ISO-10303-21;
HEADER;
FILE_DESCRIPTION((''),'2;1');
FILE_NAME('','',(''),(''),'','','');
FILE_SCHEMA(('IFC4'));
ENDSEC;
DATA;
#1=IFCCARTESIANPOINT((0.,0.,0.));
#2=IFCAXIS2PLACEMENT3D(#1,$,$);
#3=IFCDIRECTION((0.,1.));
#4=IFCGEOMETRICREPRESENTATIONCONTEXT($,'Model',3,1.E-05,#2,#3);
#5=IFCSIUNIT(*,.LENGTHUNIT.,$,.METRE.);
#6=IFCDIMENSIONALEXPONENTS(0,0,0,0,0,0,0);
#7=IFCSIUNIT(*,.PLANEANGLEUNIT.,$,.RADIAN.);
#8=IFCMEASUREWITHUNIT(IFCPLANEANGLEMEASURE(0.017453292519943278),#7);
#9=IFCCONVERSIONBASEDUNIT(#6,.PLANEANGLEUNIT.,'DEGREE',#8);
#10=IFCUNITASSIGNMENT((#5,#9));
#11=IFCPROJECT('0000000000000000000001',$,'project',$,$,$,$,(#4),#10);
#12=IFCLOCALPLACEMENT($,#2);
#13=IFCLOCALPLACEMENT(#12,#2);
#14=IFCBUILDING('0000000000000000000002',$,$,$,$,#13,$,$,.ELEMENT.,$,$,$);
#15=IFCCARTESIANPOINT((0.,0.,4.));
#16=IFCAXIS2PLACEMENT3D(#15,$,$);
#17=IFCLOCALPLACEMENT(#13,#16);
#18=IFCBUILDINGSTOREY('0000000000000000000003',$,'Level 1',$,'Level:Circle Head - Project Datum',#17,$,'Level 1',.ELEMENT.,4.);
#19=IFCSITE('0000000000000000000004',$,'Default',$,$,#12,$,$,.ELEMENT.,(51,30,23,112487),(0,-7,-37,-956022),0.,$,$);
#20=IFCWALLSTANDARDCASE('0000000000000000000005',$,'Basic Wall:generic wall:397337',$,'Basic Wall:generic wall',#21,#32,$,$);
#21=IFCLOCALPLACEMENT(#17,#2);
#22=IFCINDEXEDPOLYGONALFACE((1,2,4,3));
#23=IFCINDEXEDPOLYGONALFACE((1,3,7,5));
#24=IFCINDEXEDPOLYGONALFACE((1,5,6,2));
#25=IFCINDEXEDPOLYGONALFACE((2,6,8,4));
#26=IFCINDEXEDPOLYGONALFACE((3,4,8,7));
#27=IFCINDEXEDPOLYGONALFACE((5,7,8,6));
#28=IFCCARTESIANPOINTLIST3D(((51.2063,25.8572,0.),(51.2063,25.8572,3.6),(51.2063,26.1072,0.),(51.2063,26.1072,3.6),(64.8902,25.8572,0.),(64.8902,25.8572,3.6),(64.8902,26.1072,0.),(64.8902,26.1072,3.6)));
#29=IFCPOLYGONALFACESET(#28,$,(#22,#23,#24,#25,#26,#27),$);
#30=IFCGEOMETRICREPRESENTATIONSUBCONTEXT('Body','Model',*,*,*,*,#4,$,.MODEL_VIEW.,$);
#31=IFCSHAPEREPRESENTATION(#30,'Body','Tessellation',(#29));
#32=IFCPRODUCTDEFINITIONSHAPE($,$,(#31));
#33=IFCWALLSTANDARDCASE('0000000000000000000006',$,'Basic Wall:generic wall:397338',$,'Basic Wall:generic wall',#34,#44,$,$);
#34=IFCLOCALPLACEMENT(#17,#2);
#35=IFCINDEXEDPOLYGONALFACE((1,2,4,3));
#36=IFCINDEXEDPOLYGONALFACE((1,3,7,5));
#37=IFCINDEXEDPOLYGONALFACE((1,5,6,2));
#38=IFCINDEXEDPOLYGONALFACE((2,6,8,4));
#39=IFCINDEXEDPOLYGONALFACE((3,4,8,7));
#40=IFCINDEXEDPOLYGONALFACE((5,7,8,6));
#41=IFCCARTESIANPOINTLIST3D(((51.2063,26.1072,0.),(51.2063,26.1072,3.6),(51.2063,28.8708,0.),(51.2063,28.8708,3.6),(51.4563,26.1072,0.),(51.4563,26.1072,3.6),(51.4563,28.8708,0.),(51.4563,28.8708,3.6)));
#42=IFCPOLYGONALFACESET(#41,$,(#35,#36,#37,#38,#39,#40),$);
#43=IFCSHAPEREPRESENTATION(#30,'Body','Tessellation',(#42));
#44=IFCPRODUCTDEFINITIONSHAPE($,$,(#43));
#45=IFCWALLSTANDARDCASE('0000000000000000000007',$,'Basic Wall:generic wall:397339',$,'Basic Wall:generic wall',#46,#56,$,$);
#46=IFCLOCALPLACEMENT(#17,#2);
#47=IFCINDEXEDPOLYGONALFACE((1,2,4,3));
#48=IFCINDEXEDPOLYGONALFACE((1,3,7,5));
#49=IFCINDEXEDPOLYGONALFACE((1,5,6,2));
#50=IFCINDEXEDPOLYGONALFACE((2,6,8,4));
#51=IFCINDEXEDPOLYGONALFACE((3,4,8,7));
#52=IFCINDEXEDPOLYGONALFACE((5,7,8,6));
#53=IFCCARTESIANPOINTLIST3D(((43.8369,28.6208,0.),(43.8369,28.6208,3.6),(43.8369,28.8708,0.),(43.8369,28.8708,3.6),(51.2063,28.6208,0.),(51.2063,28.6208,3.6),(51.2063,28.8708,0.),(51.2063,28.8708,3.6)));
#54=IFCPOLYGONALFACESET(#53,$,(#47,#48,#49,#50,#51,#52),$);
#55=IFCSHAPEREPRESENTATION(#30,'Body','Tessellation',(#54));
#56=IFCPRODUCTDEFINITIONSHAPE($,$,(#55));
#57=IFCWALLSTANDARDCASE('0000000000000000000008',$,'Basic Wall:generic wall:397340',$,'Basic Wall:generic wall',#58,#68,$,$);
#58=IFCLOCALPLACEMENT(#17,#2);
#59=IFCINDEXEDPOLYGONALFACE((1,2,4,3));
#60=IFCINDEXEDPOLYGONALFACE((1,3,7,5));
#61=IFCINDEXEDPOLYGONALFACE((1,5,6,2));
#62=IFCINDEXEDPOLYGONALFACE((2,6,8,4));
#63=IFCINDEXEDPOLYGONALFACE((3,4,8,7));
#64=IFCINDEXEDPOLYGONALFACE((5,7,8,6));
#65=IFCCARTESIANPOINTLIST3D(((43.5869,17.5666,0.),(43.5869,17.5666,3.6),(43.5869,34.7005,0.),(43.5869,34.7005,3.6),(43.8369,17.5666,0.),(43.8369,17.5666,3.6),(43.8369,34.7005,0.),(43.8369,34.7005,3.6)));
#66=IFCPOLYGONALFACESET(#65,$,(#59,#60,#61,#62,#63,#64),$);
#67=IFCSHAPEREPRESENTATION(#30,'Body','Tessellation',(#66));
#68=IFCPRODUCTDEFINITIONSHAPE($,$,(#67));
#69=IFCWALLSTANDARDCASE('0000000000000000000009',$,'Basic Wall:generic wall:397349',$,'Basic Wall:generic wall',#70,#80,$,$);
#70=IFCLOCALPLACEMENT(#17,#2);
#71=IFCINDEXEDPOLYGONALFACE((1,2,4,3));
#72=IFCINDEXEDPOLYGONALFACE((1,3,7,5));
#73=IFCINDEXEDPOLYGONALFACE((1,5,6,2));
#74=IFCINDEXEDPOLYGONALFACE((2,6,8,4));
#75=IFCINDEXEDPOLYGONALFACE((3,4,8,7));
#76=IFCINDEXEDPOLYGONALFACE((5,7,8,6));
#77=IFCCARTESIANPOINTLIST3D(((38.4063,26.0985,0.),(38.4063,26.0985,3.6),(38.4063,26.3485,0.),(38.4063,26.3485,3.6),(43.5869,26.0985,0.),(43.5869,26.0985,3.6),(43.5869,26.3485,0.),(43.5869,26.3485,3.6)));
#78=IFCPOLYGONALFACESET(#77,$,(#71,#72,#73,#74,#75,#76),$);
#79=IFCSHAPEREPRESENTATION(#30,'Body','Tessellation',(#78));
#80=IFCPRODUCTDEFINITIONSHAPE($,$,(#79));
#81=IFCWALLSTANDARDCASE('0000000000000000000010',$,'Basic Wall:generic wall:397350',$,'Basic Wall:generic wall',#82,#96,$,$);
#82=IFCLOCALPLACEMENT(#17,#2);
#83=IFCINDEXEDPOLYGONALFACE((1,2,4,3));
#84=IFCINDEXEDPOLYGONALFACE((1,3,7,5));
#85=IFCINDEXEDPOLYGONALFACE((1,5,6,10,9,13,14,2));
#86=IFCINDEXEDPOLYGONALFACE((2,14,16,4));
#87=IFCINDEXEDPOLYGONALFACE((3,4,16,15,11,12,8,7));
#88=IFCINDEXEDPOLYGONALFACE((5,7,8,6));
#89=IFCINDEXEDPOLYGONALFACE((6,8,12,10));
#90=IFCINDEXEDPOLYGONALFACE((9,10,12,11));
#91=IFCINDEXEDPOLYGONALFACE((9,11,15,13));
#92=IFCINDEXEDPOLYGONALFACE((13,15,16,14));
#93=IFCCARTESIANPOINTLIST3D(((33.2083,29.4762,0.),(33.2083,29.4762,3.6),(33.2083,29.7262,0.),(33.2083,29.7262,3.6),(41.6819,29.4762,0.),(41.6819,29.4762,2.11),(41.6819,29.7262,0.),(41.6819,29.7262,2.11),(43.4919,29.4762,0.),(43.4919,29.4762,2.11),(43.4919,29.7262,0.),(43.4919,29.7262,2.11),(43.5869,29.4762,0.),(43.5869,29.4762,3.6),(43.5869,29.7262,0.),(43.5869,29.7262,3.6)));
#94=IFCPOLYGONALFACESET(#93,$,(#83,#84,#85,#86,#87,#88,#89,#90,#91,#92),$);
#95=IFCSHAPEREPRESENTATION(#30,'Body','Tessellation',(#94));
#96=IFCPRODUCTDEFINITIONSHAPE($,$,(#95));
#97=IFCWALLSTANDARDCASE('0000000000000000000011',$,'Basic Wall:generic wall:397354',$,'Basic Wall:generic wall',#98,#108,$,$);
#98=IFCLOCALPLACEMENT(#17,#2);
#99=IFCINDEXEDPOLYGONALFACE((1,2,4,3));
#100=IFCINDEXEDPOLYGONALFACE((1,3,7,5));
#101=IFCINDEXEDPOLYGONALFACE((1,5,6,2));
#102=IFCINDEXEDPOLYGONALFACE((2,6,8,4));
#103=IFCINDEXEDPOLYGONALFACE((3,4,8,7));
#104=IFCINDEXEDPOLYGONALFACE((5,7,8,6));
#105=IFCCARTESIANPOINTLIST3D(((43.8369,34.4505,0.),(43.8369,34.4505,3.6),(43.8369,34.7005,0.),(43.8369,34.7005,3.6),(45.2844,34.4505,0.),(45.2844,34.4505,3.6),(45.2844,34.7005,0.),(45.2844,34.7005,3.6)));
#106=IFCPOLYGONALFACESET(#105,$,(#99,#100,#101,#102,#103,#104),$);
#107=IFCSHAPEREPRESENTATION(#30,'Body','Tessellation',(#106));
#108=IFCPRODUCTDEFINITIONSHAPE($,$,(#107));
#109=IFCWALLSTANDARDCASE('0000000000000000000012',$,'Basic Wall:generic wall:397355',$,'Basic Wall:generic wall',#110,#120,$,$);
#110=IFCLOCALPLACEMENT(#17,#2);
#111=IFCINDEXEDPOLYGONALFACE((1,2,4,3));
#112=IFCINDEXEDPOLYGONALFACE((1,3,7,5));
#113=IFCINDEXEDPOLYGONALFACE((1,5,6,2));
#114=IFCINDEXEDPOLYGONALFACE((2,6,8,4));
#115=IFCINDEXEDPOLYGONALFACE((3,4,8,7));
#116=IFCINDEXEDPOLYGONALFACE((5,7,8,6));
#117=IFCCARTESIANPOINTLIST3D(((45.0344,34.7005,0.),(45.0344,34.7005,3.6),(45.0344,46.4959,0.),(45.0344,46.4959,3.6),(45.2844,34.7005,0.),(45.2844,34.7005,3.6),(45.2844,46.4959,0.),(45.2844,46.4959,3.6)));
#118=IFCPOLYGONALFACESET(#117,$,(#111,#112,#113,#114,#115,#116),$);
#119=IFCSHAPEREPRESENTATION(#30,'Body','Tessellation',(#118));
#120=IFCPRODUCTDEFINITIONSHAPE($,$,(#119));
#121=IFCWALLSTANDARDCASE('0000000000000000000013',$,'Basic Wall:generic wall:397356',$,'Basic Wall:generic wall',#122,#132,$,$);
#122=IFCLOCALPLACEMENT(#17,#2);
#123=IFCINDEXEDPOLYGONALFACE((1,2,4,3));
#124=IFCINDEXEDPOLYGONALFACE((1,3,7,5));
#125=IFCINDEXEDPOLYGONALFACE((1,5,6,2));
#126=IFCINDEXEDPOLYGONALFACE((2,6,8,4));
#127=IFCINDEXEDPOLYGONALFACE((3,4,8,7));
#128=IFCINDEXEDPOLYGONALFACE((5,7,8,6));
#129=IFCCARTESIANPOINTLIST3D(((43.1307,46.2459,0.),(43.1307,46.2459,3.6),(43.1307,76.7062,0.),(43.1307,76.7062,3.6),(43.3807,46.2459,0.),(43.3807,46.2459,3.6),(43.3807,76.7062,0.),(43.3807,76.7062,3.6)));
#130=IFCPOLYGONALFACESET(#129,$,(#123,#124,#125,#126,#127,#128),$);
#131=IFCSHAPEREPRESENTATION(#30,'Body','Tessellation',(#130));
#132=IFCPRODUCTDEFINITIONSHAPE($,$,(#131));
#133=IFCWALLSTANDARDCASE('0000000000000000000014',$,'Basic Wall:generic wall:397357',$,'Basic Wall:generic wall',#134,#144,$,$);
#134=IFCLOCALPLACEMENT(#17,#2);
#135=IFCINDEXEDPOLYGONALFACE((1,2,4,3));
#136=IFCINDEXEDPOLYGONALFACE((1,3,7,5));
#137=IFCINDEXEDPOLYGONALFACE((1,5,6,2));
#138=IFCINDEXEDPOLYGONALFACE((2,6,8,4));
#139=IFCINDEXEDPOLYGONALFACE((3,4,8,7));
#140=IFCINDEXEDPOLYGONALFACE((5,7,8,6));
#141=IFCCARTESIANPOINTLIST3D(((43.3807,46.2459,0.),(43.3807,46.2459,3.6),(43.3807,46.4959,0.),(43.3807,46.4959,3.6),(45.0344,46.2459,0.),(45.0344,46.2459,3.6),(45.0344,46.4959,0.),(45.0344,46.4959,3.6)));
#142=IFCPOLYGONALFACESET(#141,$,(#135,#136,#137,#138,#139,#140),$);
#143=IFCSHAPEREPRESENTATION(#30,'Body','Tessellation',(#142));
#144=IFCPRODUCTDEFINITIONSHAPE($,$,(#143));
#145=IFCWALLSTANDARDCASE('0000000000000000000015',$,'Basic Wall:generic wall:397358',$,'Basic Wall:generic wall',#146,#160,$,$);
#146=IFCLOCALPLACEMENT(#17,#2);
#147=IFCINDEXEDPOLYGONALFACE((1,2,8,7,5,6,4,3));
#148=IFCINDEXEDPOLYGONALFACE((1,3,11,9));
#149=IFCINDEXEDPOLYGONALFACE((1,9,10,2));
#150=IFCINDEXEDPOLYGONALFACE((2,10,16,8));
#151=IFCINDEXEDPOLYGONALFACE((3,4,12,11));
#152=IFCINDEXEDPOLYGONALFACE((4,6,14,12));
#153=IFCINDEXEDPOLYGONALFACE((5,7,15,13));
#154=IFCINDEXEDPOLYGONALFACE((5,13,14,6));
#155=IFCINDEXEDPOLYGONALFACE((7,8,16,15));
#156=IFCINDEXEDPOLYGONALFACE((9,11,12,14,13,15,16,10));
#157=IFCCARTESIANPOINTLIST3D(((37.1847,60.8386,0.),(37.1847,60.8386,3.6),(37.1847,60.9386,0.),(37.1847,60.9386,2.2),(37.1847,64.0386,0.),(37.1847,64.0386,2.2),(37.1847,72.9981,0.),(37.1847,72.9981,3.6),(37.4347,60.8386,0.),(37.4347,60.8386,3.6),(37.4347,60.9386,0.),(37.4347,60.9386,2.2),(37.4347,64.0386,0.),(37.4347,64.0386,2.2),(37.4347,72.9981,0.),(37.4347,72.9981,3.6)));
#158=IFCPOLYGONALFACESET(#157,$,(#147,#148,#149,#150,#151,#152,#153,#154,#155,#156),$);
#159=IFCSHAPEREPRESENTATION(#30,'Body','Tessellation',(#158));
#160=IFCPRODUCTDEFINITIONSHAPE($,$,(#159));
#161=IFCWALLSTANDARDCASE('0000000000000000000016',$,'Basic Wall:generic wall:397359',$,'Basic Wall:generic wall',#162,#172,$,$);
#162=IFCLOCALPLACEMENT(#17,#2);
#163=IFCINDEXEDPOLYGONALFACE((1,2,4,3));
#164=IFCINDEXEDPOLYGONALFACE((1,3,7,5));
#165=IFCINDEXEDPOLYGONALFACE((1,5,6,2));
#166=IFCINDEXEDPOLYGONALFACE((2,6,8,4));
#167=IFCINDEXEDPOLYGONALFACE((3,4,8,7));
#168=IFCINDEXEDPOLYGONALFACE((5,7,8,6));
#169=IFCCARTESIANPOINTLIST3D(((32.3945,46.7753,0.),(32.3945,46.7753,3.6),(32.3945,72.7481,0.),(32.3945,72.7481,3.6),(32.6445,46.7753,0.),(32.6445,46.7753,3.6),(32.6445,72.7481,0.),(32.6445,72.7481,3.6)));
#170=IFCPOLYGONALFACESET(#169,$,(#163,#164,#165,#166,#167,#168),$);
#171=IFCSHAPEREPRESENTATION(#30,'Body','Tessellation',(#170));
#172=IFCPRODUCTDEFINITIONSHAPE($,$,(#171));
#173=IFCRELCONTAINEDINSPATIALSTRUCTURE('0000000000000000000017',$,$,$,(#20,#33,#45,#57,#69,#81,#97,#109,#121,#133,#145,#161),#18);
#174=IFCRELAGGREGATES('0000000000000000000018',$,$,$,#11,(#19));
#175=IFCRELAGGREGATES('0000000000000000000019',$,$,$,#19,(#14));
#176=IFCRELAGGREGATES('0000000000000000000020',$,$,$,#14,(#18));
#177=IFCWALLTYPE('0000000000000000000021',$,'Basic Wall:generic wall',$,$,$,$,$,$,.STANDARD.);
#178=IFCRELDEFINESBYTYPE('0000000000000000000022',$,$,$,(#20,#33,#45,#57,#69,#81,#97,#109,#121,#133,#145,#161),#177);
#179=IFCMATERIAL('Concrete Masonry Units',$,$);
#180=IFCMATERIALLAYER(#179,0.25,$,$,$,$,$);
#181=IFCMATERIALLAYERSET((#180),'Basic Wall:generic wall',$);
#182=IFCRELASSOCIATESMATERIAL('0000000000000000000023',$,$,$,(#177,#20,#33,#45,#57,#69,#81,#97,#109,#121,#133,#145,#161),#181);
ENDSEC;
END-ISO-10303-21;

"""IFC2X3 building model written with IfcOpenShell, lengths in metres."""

from ifc_helpers import new_model, entity, si_unit, converted_unit, direction, frame, frame_2d, origin, place, context, subcontext, project, spatial, rectangle, extrude, material, layer, layer_set, layer_usage, type_object, element, save


model = new_model("IFC2X3")

# Units and contexts
model_context = context("Model", 3, precision=1e-05, world=origin(), true_north=direction((0.0, 1.0)))
body_context = subcontext(model_context, "Body", "Model", "MODEL_VIEW")
ifc_project = project(units=[si_unit("LENGTHUNIT", "METRE"), converted_unit("PLANEANGLEUNIT", "DEGREE", entity("IfcPlaneAngleMeasure", 0.017453292519943278), si_unit("PLANEANGLEUNIT", "RADIAN"), dimensions=[0, 0, 0, 0, 0, 0, 0])], contexts=[model_context])

# Site, building, storey
site_placement = place(None, origin())
site = spatial("IfcSite", under=ifc_project, at=site_placement, Name="Default", CompositionType="ELEMENT", RefLatitude=(51, 30, 23, 112487), RefLongitude=(0, -7, -37, -956022), RefElevation=0.0)
building_placement = place(site_placement, origin())
building = spatial("IfcBuilding", under=site, at=building_placement, CompositionType="ELEMENT")
storey_placement = place(building_placement, frame((0.0, 0.0, 4.0)))
storey = spatial("IfcBuildingStorey", under=building, at=storey_placement, Name="Level 1", ObjectType="Level:Circle Head - Project Datum", LongName="Level 1", CompositionType="ELEMENT", Elevation=4.0)

# Walls
ifc_material = material(Name="Concrete Masonry Units")
ifc_layer = layer(ifc_material, 0.25)
ifc_layer_set = layer_set([ifc_layer], Name="Basic Wall:generic wall")
ifc_layer_usage_1 = layer_usage(ifc_layer_set, "AXIS2", "NEGATIVE", 0.125)
wall_type = type_object("IfcWallType", Name="Basic Wall:generic wall", PredefinedType="STANDARD", material=ifc_layer_set)
wall_1_placement = place(storey_placement, frame((64.8902, 25.9822, 0.0), z_axis=(0.0, 0.0, 1.0), x_axis=(-1.0, 0.0, 0.0)))
element("IfcWallStandardCase", 1, at=wall_1_placement, inside=storey, type_object=wall_type, material=ifc_layer_usage_1, Name="Basic Wall:generic wall:397337", ObjectType="Basic Wall:generic wall", context=body_context, shape_type="SweptSolid", body=[
    extrude(rectangle(XDim=13.6839, YDim=0.25, at=frame_2d((6.8419, 0.0), x_axis=(-1.0, 0.0))), origin(), (0.0, 0.0, 1.0), 3.6),
])
ifc_layer_usage_2 = layer_usage(ifc_layer_set, "AXIS2", "NEGATIVE", 0.125)
wall_2_placement = place(storey_placement, frame((51.3313, 26.1072, 0.0), z_axis=(0.0, 0.0, 1.0), x_axis=(0.0, 1.0, 0.0)))
element("IfcWallStandardCase", 2, at=wall_2_placement, inside=storey, type_object=wall_type, material=ifc_layer_usage_2, Name="Basic Wall:generic wall:397338", ObjectType="Basic Wall:generic wall", context=body_context, shape_type="SweptSolid", body=[
    extrude(rectangle(XDim=2.7635, YDim=0.25, at=frame_2d((1.3818, 0.0), x_axis=(-1.0, 0.0))), origin(), (0.0, 0.0, 1.0), 3.6),
])
ifc_layer_usage_3 = layer_usage(ifc_layer_set, "AXIS2", "NEGATIVE", 0.125)
wall_3_placement = place(storey_placement, frame((51.2063, 28.7458, 0.0), z_axis=(0.0, 0.0, 1.0), x_axis=(-1.0, 0.0, 0.0)))
element("IfcWallStandardCase", 3, at=wall_3_placement, inside=storey, type_object=wall_type, material=ifc_layer_usage_3, Name="Basic Wall:generic wall:397339", ObjectType="Basic Wall:generic wall", context=body_context, shape_type="SweptSolid", body=[
    extrude(rectangle(XDim=7.3694, YDim=0.25, at=frame_2d((3.6847, 0.0), x_axis=(-1.0, 0.0))), origin(), (0.0, 0.0, 1.0), 3.6),
])
ifc_layer_usage_4 = layer_usage(ifc_layer_set, "AXIS2", "NEGATIVE", 0.125)
wall_4_placement = place(storey_placement, frame((43.7119, 34.7005, 0.0), z_axis=(0.0, 0.0, 1.0), x_axis=(0.0, -1.0, 0.0)))
element("IfcWallStandardCase", 4, at=wall_4_placement, inside=storey, type_object=wall_type, material=ifc_layer_usage_4, Name="Basic Wall:generic wall:397340", ObjectType="Basic Wall:generic wall", context=body_context, shape_type="SweptSolid", body=[
    extrude(rectangle(XDim=17.1339, YDim=0.25, at=frame_2d((8.5669, 0.0), x_axis=(-1.0, 0.0))), origin(), (0.0, 0.0, 1.0), 3.6),
])
ifc_layer_usage_5 = layer_usage(ifc_layer_set, "AXIS2", "NEGATIVE", 0.125)
wall_5_placement = place(storey_placement, frame((38.4063, 26.2235, 0.0)))
element("IfcWallStandardCase", 5, at=wall_5_placement, inside=storey, type_object=wall_type, material=ifc_layer_usage_5, Name="Basic Wall:generic wall:397349", ObjectType="Basic Wall:generic wall", context=body_context, shape_type="SweptSolid", body=[
    extrude(rectangle(XDim=5.1806, YDim=0.25, at=frame_2d((2.5903, 0.0), x_axis=(-1.0, 0.0))), origin(), (0.0, 0.0, 1.0), 3.6),
])

# Wall, opening
ifc_layer_usage_6 = layer_usage(ifc_layer_set, "AXIS2", "NEGATIVE", 0.125)
wall_6_placement = place(storey_placement, frame((33.2083, 29.6012, 0.0)))
wall_6 = element("IfcWallStandardCase", 6, at=wall_6_placement, inside=storey, type_object=wall_type, material=ifc_layer_usage_6, Name="Basic Wall:generic wall:397350", ObjectType="Basic Wall:generic wall", context=body_context, shape_type="SweptSolid", body=[
    extrude(rectangle(XDim=10.3786, YDim=0.25, at=frame_2d((5.1893, 0.0), x_axis=(-1.0, 0.0))), origin(), (0.0, 0.0, 1.0), 3.6),
])
opening_1_placement = place(wall_6_placement, frame((10.2836, 0.125, 0.0)))
element("IfcOpeningElement", 7, at=opening_1_placement, cuts=wall_6, ObjectType="Opening", context=body_context, shape_type="SweptSolid", body=[
    extrude(rectangle(XDim=2.11, YDim=1.81, at=frame_2d((1.055, 0.905), x_axis=(-1.0, 0.0))), frame((0.0, 0.0, 0.0), z_axis=(0.0, -1.0, 0.0), x_axis=(0.0, 0.0, 1.0)), (0.0, 0.0, 1.0), 0.25),
])

# Walls
ifc_layer_usage_7 = layer_usage(ifc_layer_set, "AXIS2", "NEGATIVE", 0.125)
wall_7_placement = place(storey_placement, frame((43.8369, 34.5755, 0.0)))
element("IfcWallStandardCase", 8, at=wall_7_placement, inside=storey, type_object=wall_type, material=ifc_layer_usage_7, Name="Basic Wall:generic wall:397354", ObjectType="Basic Wall:generic wall", context=body_context, shape_type="SweptSolid", body=[
    extrude(rectangle(XDim=1.4475, YDim=0.25, at=frame_2d((0.7238, 0.0), x_axis=(-1.0, 0.0))), origin(), (0.0, 0.0, 1.0), 3.6),
])
ifc_layer_usage_8 = layer_usage(ifc_layer_set, "AXIS2", "NEGATIVE", 0.125)
wall_8_placement = place(storey_placement, frame((45.1594, 34.7005, 0.0), z_axis=(0.0, 0.0, 1.0), x_axis=(0.0, 1.0, 0.0)))
element("IfcWallStandardCase", 9, at=wall_8_placement, inside=storey, type_object=wall_type, material=ifc_layer_usage_8, Name="Basic Wall:generic wall:397355", ObjectType="Basic Wall:generic wall", context=body_context, shape_type="SweptSolid", body=[
    extrude(rectangle(XDim=11.7954, YDim=0.25, at=frame_2d((5.8977, 0.0), x_axis=(-1.0, 0.0))), origin(), (0.0, 0.0, 1.0), 3.6),
])
ifc_layer_usage_9 = layer_usage(ifc_layer_set, "AXIS2", "NEGATIVE", 0.125)
wall_9_placement = place(storey_placement, frame((43.2557, 46.2459, 0.0), z_axis=(0.0, 0.0, 1.0), x_axis=(0.0, 1.0, 0.0)))
element("IfcWallStandardCase", 10, at=wall_9_placement, inside=storey, type_object=wall_type, material=ifc_layer_usage_9, Name="Basic Wall:generic wall:397356", ObjectType="Basic Wall:generic wall", context=body_context, shape_type="SweptSolid", body=[
    extrude(rectangle(XDim=30.4602, YDim=0.25, at=frame_2d((15.2301, 0.0), x_axis=(-1.0, 0.0))), origin(), (0.0, 0.0, 1.0), 3.6),
])
ifc_layer_usage_10 = layer_usage(ifc_layer_set, "AXIS2", "NEGATIVE", 0.125)
wall_10_placement = place(storey_placement, frame((45.0344, 46.3709, 0.0), z_axis=(0.0, 0.0, 1.0), x_axis=(-1.0, 0.0, 0.0)))
element("IfcWallStandardCase", 11, at=wall_10_placement, inside=storey, type_object=wall_type, material=ifc_layer_usage_10, Name="Basic Wall:generic wall:397357", ObjectType="Basic Wall:generic wall", context=body_context, shape_type="SweptSolid", body=[
    extrude(rectangle(XDim=1.6538, YDim=0.25, at=frame_2d((0.8269, 0.0), x_axis=(-1.0, 0.0))), origin(), (0.0, 0.0, 1.0), 3.6),
])

# Wall, opening
ifc_layer_usage_11 = layer_usage(ifc_layer_set, "AXIS2", "NEGATIVE", 0.125)
wall_11_placement = place(storey_placement, frame((37.3097, 72.9981, 0.0), z_axis=(0.0, 0.0, 1.0), x_axis=(0.0, -1.0, 0.0)))
wall_11 = element("IfcWallStandardCase", 12, at=wall_11_placement, inside=storey, type_object=wall_type, material=ifc_layer_usage_11, Name="Basic Wall:generic wall:397358", ObjectType="Basic Wall:generic wall", context=body_context, shape_type="SweptSolid", body=[
    extrude(rectangle(XDim=12.1595, YDim=0.25, at=frame_2d((6.0798, 0.0), x_axis=(-1.0, 0.0))), origin(), (0.0, 0.0, 1.0), 3.6),
])
opening_2_placement = place(wall_11_placement, frame((12.0595, 0.125, 0.0)))
element("IfcOpeningElement", 13, at=opening_2_placement, cuts=wall_11, ObjectType="Opening", context=body_context, shape_type="SweptSolid", body=[
    extrude(rectangle(XDim=2.2, YDim=3.1, at=frame_2d((1.1, 1.55), x_axis=(1.0, 0.0))), frame((0.0, 0.0, 0.0), z_axis=(0.0, -1.0, 0.0), x_axis=(0.0, 0.0, 1.0)), (0.0, 0.0, 1.0), 0.25),
])

# Wall
ifc_layer_usage_12 = layer_usage(ifc_layer_set, "AXIS2", "NEGATIVE", 0.125)
wall_12_placement = place(storey_placement, frame((32.5195, 72.7481, 0.0), z_axis=(0.0, 0.0, 1.0), x_axis=(0.0, -1.0, 0.0)))
element("IfcWallStandardCase", 14, at=wall_12_placement, inside=storey, type_object=wall_type, material=ifc_layer_usage_12, Name="Basic Wall:generic wall:397359", ObjectType="Basic Wall:generic wall", context=body_context, shape_type="SweptSolid", body=[
    extrude(rectangle(XDim=25.9728, YDim=0.25, at=frame_2d((12.9864, 0.0), x_axis=(-1.0, 0.0))), origin(), (0.0, 0.0, 1.0), 3.6),
])

save(model, "model.ifc")
